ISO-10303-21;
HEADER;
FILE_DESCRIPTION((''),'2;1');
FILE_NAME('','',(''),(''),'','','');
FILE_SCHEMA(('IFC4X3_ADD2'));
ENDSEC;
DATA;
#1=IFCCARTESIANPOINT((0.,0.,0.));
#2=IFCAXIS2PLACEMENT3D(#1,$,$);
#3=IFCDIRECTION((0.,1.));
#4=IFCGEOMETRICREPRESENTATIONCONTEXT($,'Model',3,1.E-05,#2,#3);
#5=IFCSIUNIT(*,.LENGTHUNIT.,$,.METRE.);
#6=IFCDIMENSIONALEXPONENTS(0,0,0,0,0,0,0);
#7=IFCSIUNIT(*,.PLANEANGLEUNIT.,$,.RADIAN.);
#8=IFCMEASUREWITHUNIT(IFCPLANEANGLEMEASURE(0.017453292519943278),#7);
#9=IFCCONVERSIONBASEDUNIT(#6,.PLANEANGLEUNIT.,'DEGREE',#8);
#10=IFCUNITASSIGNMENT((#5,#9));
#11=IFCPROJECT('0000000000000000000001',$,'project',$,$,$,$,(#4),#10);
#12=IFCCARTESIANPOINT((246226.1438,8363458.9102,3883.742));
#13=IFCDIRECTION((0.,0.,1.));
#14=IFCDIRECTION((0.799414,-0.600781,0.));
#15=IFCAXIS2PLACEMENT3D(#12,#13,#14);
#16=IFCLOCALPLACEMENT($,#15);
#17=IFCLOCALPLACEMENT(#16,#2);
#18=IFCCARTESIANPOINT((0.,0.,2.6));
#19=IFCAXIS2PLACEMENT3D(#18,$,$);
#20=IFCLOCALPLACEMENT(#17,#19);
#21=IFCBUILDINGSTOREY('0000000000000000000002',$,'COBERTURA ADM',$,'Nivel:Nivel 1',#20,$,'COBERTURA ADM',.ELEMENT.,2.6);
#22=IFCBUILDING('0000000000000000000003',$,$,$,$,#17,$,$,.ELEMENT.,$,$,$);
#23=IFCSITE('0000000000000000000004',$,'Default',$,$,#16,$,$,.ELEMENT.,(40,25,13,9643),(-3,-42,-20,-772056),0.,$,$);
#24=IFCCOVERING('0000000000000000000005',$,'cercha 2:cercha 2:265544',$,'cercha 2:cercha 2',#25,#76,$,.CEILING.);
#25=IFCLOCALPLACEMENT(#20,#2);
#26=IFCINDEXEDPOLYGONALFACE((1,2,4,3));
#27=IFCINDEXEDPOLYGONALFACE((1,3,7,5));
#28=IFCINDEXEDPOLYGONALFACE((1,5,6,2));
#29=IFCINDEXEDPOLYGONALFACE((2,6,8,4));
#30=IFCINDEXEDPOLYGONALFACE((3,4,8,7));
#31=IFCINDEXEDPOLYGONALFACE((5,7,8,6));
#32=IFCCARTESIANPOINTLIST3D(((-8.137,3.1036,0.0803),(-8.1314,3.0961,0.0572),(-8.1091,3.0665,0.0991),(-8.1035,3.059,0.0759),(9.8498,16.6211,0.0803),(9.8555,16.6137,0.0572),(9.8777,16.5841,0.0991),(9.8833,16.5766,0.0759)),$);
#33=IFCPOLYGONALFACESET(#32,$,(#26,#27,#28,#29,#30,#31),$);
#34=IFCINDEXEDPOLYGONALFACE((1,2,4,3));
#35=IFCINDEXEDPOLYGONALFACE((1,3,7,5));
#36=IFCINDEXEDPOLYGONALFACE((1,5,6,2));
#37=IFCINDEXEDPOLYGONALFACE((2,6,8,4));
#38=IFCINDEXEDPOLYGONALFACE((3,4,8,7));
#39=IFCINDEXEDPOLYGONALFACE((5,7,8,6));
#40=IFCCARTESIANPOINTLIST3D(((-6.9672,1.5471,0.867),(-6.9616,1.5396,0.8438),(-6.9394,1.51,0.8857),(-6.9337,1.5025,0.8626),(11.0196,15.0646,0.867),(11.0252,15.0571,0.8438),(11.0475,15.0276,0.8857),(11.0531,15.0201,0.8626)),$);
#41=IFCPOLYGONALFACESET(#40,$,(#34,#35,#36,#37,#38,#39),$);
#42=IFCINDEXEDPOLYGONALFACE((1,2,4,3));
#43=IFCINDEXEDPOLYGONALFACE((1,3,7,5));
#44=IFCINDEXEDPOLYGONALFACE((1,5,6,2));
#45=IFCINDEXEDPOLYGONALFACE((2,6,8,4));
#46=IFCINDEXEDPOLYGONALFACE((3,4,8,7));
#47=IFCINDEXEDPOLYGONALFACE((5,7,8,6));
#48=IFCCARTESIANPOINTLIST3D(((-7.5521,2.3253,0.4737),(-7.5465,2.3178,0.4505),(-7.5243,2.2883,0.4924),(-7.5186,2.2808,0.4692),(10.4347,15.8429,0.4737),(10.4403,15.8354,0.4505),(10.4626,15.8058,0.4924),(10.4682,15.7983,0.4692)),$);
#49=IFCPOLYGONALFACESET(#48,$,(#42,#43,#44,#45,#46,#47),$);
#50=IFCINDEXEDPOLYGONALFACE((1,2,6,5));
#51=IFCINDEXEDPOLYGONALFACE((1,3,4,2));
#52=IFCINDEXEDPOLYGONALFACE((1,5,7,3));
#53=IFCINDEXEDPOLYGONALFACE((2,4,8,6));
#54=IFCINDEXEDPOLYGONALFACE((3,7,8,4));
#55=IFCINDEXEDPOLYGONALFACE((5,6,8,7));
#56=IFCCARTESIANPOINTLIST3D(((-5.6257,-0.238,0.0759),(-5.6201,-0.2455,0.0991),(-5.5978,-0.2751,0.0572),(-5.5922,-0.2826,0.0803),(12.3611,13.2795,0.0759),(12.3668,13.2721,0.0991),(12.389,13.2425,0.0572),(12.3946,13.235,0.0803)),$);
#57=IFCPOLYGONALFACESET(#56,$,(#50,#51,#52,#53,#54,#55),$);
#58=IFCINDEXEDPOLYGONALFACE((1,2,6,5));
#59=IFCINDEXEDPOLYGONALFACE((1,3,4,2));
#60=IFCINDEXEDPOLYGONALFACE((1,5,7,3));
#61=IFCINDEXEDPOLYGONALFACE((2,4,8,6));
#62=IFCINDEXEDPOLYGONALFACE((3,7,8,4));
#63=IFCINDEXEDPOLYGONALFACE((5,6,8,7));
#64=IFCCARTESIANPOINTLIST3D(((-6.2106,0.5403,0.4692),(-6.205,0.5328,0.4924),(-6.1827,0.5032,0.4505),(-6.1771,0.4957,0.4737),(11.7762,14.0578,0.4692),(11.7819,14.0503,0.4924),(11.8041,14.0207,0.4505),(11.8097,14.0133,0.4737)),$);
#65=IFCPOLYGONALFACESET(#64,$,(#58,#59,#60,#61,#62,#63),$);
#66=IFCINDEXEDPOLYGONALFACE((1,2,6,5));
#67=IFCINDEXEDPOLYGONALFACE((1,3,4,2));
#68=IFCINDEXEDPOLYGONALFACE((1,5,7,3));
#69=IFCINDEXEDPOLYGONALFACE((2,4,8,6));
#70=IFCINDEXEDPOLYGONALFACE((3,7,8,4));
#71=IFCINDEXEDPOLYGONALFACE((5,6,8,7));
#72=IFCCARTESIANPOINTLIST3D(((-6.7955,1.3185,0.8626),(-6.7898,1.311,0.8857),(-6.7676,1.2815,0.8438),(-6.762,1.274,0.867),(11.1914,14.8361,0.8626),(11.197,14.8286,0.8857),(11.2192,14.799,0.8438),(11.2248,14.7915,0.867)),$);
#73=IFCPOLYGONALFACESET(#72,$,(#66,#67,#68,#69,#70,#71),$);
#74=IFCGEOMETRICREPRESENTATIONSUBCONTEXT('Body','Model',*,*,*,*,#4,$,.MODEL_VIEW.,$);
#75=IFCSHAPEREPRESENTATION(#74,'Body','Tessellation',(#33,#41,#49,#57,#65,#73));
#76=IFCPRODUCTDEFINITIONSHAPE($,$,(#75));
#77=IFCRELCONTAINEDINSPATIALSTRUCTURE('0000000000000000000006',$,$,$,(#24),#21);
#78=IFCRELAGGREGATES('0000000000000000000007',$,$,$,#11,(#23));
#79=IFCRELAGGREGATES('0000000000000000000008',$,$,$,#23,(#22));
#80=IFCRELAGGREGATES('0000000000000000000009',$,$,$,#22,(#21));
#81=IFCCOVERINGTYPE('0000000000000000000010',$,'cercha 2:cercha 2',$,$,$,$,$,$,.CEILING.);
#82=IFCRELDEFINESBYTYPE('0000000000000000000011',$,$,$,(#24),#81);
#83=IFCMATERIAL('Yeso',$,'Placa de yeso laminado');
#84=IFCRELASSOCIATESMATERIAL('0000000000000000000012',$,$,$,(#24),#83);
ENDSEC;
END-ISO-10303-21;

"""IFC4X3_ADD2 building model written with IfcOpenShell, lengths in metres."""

from ifc_helpers import new_model, entity, si_unit, converted_unit, direction, frame, frame_2d, origin, place, context, subcontext, project, spatial, rectangle, extrude, material, type_object, element, save


model = new_model("IFC4X3_ADD2")

# Units and contexts
model_context = context("Model", 3, precision=1e-05, world=origin(), true_north=direction((0.0, 1.0)))
body_context = subcontext(model_context, "Body", "Model", "MODEL_VIEW")
ifc_project = project(units=[si_unit("LENGTHUNIT", "METRE"), converted_unit("PLANEANGLEUNIT", "DEGREE", entity("IfcPlaneAngleMeasure", 0.017453292519943278), si_unit("PLANEANGLEUNIT", "RADIAN"), dimensions=[0, 0, 0, 0, 0, 0, 0])], contexts=[model_context])

# Site, building, storey
site_placement = place(None, frame((246226.1438, 8363458.9102, 3883.742), z_axis=(0.0, 0.0, 1.0), x_axis=(0.799414, -0.600781, 0.0)))
site = spatial("IfcSite", under=ifc_project, at=site_placement, Name="Default", CompositionType="ELEMENT", RefLatitude=(40, 25, 13, 9643), RefLongitude=(-3, -42, -20, -772056), RefElevation=0.0)
building_placement = place(site_placement, origin())
building = spatial("IfcBuilding", under=site, at=building_placement, CompositionType="ELEMENT")
storey_placement = place(building_placement, frame((0.0, 0.0, 2.6)))
storey = spatial("IfcBuildingStorey", under=building, at=storey_placement, Name="COBERTURA ADM", ObjectType="Nivel:Nivel 1", LongName="COBERTURA ADM", CompositionType="ELEMENT", Elevation=2.6)

# Covering
ifc_material_1 = material(Name="Yeso", Category="Placa de yeso laminado")
covering_type = type_object("IfcCoveringType", Name="cercha 2:cercha 2", PredefinedType="CEILING")
covering_placement = place(storey_placement, frame((-8.137, -0.2826, 0.0572)))
element("IfcCovering", 1, at=covering_placement, inside=storey, type_object=covering_type, material=ifc_material_1, Name="cercha 2:cercha 2:265544", ObjectType="cercha 2:cercha 2", PredefinedType="CEILING", context=body_context, shape_type="SweptSolid", body=[
    extrude(rectangle(XDim=0.025, YDim=0.05, at=frame_2d((0.0, 0.0), x_axis=(0.0, 1.0))), frame((0.0167, 3.3639, 0.021), z_axis=(0.799414, 0.60078, 0.0), x_axis=(0.557033, -0.741204, 0.374607)), (0.0, 0.0, 1.0), 22.5),
    extrude(rectangle(XDim=0.025, YDim=0.05, at=frame_2d((0.0, 0.0), x_axis=(0.0, 1.0))), frame((1.1865, 1.8073, 0.8076), z_axis=(0.799414, 0.60078, 0.0), x_axis=(0.557033, -0.741204, 0.374607)), (0.0, 0.0, 1.0), 22.5),
    extrude(rectangle(XDim=0.025, YDim=0.05, at=frame_2d((0.0, 0.0), x_axis=(0.0, 1.0))), frame((0.6016, 2.5856, 0.4143), z_axis=(0.799414, 0.60078, 0.0), x_axis=(0.557033, -0.741204, 0.374607)), (0.0, 0.0, 1.0), 22.5),
    extrude(rectangle(XDim=0.025, YDim=0.05, at=frame_2d((0.0, 0.0), x_axis=(1.0, 0.0))), frame((2.528, 0.0223, 0.021), z_axis=(0.799414, 0.60078, 0.0), x_axis=(-0.225056, 0.299466, -0.927184)), (0.0, 0.0, 1.0), 22.5),
    extrude(rectangle(XDim=0.025, YDim=0.05, at=frame_2d((0.0, 0.0), x_axis=(1.0, 0.0))), frame((1.9432, 0.8005, 0.4143), z_axis=(0.799414, 0.60078, 0.0), x_axis=(-0.225056, 0.299466, -0.927184)), (0.0, 0.0, 1.0), 22.5),
    extrude(rectangle(XDim=0.025, YDim=0.05, at=frame_2d((0.0, 0.0), x_axis=(1.0, 0.0))), frame((1.3583, 1.5788, 0.8076), z_axis=(0.799414, 0.60078, 0.0), x_axis=(-0.225056, 0.299466, -0.927184)), (0.0, 0.0, 1.0), 22.5),
])

save(model, "model.ifc")
